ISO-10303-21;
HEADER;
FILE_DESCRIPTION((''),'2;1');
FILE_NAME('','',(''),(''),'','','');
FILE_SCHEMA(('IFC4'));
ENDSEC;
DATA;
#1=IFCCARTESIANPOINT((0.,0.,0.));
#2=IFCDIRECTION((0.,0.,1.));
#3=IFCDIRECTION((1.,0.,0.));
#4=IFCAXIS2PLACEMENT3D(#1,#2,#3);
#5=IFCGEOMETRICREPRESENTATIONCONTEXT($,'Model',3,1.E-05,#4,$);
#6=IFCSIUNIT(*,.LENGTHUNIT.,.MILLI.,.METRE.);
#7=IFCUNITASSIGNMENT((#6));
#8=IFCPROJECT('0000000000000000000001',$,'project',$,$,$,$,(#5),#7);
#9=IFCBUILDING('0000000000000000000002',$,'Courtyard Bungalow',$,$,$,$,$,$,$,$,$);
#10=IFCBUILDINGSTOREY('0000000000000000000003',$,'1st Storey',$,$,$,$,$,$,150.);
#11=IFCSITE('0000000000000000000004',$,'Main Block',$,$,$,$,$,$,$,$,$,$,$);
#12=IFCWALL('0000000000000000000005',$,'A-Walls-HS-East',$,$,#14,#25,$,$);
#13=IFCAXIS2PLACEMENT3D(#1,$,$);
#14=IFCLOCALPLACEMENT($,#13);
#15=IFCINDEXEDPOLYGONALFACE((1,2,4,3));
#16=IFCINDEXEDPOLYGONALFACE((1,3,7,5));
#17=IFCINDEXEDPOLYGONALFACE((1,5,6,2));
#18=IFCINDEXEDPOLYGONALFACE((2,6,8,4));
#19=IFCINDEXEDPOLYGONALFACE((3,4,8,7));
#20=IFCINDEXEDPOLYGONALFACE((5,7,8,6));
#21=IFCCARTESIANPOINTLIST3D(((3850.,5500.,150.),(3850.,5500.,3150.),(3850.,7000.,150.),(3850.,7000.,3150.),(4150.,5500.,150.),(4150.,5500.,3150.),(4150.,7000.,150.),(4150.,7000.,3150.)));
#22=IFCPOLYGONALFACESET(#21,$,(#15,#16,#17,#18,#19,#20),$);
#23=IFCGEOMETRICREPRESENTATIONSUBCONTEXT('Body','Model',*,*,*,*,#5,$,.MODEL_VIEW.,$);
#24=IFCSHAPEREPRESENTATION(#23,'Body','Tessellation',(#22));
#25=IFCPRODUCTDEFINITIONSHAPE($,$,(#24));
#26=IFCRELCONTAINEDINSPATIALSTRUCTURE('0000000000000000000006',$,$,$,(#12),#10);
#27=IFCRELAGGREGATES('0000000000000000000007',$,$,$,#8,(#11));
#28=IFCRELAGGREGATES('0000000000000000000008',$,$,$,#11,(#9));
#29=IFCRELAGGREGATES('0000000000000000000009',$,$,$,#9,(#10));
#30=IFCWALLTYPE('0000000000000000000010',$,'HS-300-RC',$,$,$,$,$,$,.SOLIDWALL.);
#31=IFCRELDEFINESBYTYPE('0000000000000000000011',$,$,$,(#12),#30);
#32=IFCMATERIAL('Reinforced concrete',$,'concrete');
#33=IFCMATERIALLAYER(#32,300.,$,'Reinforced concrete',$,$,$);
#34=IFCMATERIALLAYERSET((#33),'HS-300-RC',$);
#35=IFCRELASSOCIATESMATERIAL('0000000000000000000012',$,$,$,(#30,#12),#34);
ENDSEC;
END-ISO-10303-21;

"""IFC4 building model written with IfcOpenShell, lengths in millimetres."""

from ifc_helpers import new_model, si_unit, frame, origin_with_axes, place, context, subcontext, project, spatial, indexed_curve, outline, extrude, material, layer, layer_set, layer_usage, type_object, element, save


model = new_model("IFC4")

# Units and contexts
model_context = context("Model", 3, precision=1e-05, world=origin_with_axes())
body_context = subcontext(model_context, "Body", "Model", "MODEL_VIEW")
ifc_project = project(units=[si_unit("LENGTHUNIT", "METRE", prefix="MILLI")], contexts=[model_context])

# Site, building, storey
site = spatial("IfcSite", under=ifc_project, Name="Main Block")
building = spatial("IfcBuilding", under=site, Name="Courtyard Bungalow")
storey = spatial("IfcBuildingStorey", under=building, Name="1st Storey", Elevation=150.0)

# Wall
ifc_material_1 = material(Name="Reinforced concrete", Category="concrete")
ifc_layer_1 = layer(ifc_material_1, 300.0, Name="Reinforced concrete")
ifc_layer_set_1 = layer_set([ifc_layer_1], Name="HS-300-RC")
ifc_layer_usage_1 = layer_usage(ifc_layer_set_1, "AXIS2", "POSITIVE", 0.0)
wall_type_1 = type_object("IfcWallType", Name="HS-300-RC", PredefinedType="SOLIDWALL", material=ifc_layer_set_1)
wall_1_placement = place(None, frame((4150.0, 5500.0, 150.0), z_axis=(0.0, 0.0, 1.0), x_axis=(0.0, 1.0, 0.0)))
element("IfcWall", 1, at=wall_1_placement, inside=storey, type_object=wall_type_1, material=ifc_layer_usage_1, Name="A-Walls-HS-East", context=body_context, shape_type="SweptSolid", body=[
    extrude(outline(indexed_curve([(0.0, 0.0), (0.0, 300.0), (1500.0, 300.0), (1500.0, 0.0), (0.0, 0.0)], self_intersect=False)), origin_with_axes(), (0.0, 0.0, 1.0), 3000.0),
])

save(model, "model.ifc")
